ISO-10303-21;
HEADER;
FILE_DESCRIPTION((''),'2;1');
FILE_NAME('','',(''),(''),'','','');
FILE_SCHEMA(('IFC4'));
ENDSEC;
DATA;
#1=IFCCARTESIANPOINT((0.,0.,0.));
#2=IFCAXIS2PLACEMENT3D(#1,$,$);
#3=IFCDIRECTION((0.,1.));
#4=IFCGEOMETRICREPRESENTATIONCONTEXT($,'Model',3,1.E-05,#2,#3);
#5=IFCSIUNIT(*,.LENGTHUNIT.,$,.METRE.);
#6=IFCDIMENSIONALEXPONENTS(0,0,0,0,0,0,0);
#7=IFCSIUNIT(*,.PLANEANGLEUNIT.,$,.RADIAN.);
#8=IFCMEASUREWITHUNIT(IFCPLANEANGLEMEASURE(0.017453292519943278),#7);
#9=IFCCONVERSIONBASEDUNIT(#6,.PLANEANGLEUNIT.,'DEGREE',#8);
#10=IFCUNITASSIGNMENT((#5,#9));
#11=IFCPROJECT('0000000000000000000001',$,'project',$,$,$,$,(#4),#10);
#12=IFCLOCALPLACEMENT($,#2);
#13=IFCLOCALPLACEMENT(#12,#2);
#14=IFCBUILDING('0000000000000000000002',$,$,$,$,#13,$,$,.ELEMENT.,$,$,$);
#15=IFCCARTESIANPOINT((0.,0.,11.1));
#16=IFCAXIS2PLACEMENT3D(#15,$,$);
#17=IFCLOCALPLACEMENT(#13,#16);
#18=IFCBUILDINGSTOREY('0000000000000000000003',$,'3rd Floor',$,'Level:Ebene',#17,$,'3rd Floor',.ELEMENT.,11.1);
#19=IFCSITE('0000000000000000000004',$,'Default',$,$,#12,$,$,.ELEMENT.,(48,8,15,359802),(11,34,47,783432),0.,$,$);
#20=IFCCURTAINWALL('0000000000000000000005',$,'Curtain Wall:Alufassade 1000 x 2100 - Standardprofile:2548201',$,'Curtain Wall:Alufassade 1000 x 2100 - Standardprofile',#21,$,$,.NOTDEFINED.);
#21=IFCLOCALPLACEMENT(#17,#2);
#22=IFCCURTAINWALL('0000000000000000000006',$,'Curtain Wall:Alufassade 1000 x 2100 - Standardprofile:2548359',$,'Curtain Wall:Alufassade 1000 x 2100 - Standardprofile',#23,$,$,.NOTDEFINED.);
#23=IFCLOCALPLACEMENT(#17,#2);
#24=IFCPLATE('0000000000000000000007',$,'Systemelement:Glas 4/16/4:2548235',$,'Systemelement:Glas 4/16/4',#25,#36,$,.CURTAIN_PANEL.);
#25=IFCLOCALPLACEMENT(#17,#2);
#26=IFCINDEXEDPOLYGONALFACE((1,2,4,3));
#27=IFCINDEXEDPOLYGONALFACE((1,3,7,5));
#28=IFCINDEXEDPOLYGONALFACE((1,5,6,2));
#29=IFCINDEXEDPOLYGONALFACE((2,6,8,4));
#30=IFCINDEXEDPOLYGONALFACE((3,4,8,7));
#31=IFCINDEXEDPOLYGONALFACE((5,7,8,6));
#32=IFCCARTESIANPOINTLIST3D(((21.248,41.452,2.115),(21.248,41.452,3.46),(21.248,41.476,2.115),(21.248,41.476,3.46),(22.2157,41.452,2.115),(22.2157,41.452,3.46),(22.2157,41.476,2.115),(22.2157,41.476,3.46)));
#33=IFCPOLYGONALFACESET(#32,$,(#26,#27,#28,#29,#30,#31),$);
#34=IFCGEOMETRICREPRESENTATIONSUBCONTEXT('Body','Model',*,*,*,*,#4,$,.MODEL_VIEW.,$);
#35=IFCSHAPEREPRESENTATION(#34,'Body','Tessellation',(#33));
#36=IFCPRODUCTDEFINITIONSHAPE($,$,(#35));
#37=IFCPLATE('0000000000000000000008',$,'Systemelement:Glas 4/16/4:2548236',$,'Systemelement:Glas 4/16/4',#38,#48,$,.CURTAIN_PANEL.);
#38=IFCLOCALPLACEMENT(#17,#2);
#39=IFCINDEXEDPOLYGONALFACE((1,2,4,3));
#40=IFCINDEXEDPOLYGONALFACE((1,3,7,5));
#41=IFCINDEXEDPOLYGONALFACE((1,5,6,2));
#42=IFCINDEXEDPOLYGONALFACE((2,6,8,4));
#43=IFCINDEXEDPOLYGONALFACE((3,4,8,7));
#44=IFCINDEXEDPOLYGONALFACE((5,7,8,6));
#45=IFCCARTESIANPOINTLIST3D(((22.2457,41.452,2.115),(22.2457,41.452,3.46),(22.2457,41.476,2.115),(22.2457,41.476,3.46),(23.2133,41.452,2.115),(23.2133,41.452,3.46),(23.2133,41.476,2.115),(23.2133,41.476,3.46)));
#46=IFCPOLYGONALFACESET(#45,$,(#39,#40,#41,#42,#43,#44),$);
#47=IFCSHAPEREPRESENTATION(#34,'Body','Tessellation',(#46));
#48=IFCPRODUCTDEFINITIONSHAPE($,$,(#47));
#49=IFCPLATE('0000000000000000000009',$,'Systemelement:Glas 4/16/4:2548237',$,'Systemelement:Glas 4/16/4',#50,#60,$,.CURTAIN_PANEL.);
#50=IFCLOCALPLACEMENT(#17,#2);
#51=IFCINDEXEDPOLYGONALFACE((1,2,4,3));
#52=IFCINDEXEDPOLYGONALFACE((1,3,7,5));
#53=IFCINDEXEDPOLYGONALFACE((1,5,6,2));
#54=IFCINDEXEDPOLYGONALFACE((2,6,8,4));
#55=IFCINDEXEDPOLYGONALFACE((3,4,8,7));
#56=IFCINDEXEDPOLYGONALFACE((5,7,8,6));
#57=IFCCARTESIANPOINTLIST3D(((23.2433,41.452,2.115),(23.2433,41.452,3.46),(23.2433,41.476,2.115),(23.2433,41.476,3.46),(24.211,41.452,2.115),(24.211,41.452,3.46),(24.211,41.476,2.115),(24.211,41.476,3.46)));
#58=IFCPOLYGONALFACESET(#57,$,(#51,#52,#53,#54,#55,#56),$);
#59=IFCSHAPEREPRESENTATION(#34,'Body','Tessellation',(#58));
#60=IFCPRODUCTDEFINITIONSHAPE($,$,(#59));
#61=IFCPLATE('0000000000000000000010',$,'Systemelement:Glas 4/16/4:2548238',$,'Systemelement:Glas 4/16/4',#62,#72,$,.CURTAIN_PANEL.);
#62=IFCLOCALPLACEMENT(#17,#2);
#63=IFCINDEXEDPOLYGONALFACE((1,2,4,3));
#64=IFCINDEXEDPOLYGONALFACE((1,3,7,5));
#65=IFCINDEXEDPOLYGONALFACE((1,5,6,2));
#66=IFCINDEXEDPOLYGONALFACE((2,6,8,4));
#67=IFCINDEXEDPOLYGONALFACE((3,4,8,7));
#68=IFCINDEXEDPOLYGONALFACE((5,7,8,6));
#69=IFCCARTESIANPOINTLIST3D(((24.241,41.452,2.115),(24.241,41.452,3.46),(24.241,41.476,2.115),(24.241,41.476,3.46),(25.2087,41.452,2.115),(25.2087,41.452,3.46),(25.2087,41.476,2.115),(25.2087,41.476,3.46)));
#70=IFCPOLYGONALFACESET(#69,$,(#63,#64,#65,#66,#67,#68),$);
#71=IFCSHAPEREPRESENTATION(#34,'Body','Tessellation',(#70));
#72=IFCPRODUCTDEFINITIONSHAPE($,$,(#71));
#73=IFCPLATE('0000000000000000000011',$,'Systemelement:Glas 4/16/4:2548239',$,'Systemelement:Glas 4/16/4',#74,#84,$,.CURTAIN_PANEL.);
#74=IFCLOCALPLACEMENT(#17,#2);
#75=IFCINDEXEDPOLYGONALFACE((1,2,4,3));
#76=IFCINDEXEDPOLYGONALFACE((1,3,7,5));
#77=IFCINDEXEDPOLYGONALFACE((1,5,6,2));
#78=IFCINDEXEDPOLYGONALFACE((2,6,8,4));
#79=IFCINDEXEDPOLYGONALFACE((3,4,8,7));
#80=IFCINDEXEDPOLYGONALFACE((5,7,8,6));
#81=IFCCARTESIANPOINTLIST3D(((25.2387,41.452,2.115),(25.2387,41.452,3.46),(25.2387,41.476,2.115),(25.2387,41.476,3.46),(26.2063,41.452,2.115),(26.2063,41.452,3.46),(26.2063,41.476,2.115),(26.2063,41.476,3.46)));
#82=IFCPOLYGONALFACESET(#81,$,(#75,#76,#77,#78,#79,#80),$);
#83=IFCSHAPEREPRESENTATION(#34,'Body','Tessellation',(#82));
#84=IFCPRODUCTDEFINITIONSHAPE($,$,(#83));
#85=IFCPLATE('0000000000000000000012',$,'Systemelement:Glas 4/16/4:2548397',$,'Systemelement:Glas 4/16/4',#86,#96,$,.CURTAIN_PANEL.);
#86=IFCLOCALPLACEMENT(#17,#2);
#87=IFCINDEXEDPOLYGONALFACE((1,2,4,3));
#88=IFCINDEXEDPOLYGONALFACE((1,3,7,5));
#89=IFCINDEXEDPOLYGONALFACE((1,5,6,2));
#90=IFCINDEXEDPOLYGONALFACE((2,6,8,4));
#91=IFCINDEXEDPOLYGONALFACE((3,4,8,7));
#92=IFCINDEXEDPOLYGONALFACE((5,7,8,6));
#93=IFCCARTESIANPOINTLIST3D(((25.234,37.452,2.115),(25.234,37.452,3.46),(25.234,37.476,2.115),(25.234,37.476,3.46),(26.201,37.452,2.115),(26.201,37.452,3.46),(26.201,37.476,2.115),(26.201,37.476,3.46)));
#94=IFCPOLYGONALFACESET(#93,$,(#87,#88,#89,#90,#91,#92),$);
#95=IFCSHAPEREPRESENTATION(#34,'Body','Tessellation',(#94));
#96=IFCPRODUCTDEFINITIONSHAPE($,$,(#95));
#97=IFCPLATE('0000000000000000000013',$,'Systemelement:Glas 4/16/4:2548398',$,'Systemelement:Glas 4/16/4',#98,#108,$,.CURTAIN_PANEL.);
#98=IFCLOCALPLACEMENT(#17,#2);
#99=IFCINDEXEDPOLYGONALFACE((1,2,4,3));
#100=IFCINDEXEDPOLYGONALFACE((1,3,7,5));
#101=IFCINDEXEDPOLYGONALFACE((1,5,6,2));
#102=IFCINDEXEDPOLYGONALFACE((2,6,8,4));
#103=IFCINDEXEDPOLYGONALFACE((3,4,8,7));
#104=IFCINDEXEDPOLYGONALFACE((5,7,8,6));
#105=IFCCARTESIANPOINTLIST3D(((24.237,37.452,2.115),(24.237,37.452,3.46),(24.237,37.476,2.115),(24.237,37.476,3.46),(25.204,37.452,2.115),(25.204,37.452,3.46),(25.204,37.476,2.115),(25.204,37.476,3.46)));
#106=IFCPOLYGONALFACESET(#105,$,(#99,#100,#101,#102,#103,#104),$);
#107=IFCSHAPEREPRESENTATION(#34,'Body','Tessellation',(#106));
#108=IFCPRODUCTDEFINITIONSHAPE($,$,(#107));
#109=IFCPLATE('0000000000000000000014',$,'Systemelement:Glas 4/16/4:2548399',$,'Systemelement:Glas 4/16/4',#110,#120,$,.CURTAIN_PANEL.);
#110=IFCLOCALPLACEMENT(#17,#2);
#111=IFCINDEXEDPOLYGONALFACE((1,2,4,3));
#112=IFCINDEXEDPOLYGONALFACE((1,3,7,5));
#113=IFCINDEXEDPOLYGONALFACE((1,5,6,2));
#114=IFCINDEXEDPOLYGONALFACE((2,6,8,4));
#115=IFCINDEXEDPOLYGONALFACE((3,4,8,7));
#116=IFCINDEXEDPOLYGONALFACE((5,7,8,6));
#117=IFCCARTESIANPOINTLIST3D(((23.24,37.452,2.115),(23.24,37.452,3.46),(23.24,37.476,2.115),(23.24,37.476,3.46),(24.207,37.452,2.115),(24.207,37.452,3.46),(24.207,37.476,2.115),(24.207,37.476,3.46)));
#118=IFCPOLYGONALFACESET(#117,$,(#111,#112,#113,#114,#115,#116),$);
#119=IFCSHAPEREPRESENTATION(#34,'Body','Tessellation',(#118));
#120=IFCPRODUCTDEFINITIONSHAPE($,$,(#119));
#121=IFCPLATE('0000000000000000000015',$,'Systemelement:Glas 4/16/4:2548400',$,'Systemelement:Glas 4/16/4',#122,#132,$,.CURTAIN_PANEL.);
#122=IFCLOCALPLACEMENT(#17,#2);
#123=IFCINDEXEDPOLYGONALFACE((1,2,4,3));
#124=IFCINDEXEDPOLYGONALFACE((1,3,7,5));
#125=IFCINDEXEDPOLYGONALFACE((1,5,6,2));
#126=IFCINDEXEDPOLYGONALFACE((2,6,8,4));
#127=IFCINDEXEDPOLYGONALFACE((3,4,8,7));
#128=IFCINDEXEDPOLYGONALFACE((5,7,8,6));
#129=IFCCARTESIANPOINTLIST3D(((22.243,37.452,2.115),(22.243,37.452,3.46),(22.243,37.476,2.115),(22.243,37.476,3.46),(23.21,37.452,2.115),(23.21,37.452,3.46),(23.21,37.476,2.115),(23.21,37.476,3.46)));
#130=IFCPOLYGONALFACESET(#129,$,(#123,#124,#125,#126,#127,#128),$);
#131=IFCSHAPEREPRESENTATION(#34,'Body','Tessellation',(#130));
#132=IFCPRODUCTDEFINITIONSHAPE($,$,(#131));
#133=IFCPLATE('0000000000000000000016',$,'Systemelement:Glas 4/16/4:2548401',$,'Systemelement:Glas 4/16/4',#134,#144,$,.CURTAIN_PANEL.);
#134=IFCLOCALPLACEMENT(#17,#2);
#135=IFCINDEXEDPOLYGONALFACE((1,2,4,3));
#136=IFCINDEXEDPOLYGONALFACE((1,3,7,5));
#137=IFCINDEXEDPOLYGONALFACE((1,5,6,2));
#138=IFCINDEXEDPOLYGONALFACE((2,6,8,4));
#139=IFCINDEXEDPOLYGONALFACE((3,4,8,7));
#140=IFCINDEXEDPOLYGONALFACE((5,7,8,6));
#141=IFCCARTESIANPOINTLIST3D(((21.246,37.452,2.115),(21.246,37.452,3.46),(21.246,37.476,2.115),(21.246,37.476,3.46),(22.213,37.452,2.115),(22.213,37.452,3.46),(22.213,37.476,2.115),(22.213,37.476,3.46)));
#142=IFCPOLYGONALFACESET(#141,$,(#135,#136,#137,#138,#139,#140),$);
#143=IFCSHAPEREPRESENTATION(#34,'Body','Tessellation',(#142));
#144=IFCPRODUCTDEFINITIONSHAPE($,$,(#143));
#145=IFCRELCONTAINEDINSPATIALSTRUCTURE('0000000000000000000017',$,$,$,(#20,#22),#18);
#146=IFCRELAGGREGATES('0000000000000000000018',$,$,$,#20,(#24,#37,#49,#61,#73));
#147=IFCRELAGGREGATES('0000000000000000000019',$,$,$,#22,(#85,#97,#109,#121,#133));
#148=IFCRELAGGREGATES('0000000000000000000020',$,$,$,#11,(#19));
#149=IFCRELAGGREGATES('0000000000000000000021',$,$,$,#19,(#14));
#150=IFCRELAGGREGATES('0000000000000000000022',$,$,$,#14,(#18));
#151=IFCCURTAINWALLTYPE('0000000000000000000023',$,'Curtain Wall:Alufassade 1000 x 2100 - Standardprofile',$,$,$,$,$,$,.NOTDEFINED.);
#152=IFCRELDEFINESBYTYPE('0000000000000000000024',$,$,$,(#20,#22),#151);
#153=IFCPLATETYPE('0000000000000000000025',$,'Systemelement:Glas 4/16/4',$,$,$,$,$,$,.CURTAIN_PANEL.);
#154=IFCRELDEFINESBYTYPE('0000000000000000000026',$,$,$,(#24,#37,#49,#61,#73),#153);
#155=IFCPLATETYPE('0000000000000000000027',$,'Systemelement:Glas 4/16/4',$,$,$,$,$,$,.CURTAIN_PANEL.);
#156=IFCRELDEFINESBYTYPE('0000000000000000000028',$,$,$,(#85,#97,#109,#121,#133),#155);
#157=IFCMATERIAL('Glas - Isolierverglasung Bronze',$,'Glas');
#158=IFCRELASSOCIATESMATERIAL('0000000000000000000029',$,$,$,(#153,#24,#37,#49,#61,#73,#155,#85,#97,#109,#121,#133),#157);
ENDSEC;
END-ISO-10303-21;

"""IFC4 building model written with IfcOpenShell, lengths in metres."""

from ifc_helpers import new_model, entity, si_unit, converted_unit, direction, frame, origin, place, context, subcontext, project, spatial, indexed_curve, outline, extrude, source, transform, mapped, material, type_object, type_shapes, element, aggregate, save


model = new_model("IFC4")

# Units and contexts
model_context = context("Model", 3, precision=1e-05, world=origin(), true_north=direction((0.0, 1.0)))
body_context = subcontext(model_context, "Body", "Model", "MODEL_VIEW")
ifc_project = project(units=[si_unit("LENGTHUNIT", "METRE"), converted_unit("PLANEANGLEUNIT", "DEGREE", entity("IfcPlaneAngleMeasure", 0.017453292519943278), si_unit("PLANEANGLEUNIT", "RADIAN"), dimensions=[0, 0, 0, 0, 0, 0, 0])], contexts=[model_context])

# Site, building, storey
site_placement = place(None, origin())
site = spatial("IfcSite", under=ifc_project, at=site_placement, Name="Default", CompositionType="ELEMENT", RefLatitude=(48, 8, 15, 359802), RefLongitude=(11, 34, 47, 783432), RefElevation=0.0)
building_placement = place(site_placement, origin())
building = spatial("IfcBuilding", under=site, at=building_placement, CompositionType="ELEMENT")
storey_placement = place(building_placement, frame((0.0, 0.0, 11.1)))
storey = spatial("IfcBuildingStorey", under=building, at=storey_placement, Name="3rd Floor", ObjectType="Level:Ebene", LongName="3rd Floor", CompositionType="ELEMENT", Elevation=11.1)

# Curtain walls
curtain_wall_type = type_object("IfcCurtainWallType", Name="Curtain Wall:Alufassade 1000 x 2100 - Standardprofile", PredefinedType="NOTDEFINED")
curtain_wall_1_placement = place(storey_placement, frame((0.0, 0.0, -11.1)))
curtain_wall_1 = element("IfcCurtainWall", 1, at=curtain_wall_1_placement, inside=storey, type_object=curtain_wall_type, Name="Curtain Wall:Alufassade 1000 x 2100 - Standardprofile:2548201", ObjectType="Curtain Wall:Alufassade 1000 x 2100 - Standardprofile", PredefinedType="NOTDEFINED")
curtain_wall_2_placement = place(storey_placement, frame((0.0, 0.0, -11.1)))
curtain_wall_2 = element("IfcCurtainWall", 2, at=curtain_wall_2_placement, inside=storey, type_object=curtain_wall_type, Name="Curtain Wall:Alufassade 1000 x 2100 - Standardprofile:2548359", ObjectType="Curtain Wall:Alufassade 1000 x 2100 - Standardprofile", PredefinedType="NOTDEFINED")

# Plates
ifc_material_1 = material(Name="Glas - Isolierverglasung Bronze", Category="Glas")
plate_type_1 = type_object("IfcPlateType", Name="Systemelement:Glas 4/16/4", PredefinedType="CURTAIN_PANEL", material=ifc_material_1)
shared_shape_1 = source(origin(), body_context, "Body", "SweptSolid", [
    extrude(outline(indexed_curve([(-0.012, -0.4838), (0.012, -0.4838), (0.012, 0.4838), (-0.012, 0.4838), (-0.012, -0.4838)], self_intersect=False)), frame((0.0, 0.0, 0.0), z_axis=(0.0, 0.0, 1.0), x_axis=(0.0, 1.0, 0.0)), (0.0, 0.0, 1.0), 1.345),
])
type_shapes(plate_type_1, [shared_shape_1])
plate_1_placement = place(curtain_wall_1_placement, frame((21.7318, 41.464, 13.215)))
plate_1 = element("IfcPlate", 3, at=plate_1_placement, type_object=plate_type_1, material=ifc_material_1, Name="Systemelement:Glas 4/16/4:2548235", ObjectType="Systemelement:Glas 4/16/4", PredefinedType="CURTAIN_PANEL", context=body_context, shape_type="MappedRepresentation", body=[
    mapped(shared_shape_1, transform((0.0, 0.0, 0.0), scale=1.0)),
])
plate_2_placement = place(curtain_wall_1_placement, frame((22.7295, 41.464, 13.215)))
plate_2 = element("IfcPlate", 4, at=plate_2_placement, type_object=plate_type_1, material=ifc_material_1, Name="Systemelement:Glas 4/16/4:2548236", ObjectType="Systemelement:Glas 4/16/4", PredefinedType="CURTAIN_PANEL", context=body_context, shape_type="MappedRepresentation", body=[
    mapped(shared_shape_1, transform((0.0, 0.0, 0.0), scale=1.0)),
])
plate_3_placement = place(curtain_wall_1_placement, frame((23.7272, 41.464, 13.215)))
plate_3 = element("IfcPlate", 5, at=plate_3_placement, type_object=plate_type_1, material=ifc_material_1, Name="Systemelement:Glas 4/16/4:2548237", ObjectType="Systemelement:Glas 4/16/4", PredefinedType="CURTAIN_PANEL", context=body_context, shape_type="MappedRepresentation", body=[
    mapped(shared_shape_1, transform((0.0, 0.0, 0.0), scale=1.0)),
])
plate_4_placement = place(curtain_wall_1_placement, frame((24.7248, 41.464, 13.215)))
plate_4 = element("IfcPlate", 6, at=plate_4_placement, type_object=plate_type_1, material=ifc_material_1, Name="Systemelement:Glas 4/16/4:2548238", ObjectType="Systemelement:Glas 4/16/4", PredefinedType="CURTAIN_PANEL", context=body_context, shape_type="MappedRepresentation", body=[
    mapped(shared_shape_1, transform((0.0, 0.0, 0.0), scale=1.0)),
])
plate_5_placement = place(curtain_wall_1_placement, frame((25.7225, 41.464, 13.215)))
plate_5 = element("IfcPlate", 7, at=plate_5_placement, type_object=plate_type_1, material=ifc_material_1, Name="Systemelement:Glas 4/16/4:2548239", ObjectType="Systemelement:Glas 4/16/4", PredefinedType="CURTAIN_PANEL", context=body_context, shape_type="MappedRepresentation", body=[
    mapped(shared_shape_1, transform((0.0, 0.0, 0.0), scale=1.0)),
])
aggregate(curtain_wall_1, [plate_1, plate_2, plate_3, plate_4, plate_5])
plate_type_2 = type_object("IfcPlateType", Name="Systemelement:Glas 4/16/4", PredefinedType="CURTAIN_PANEL", material=ifc_material_1)
shared_shape_2 = source(origin(), body_context, "Body", "SweptSolid", [
    extrude(outline(indexed_curve([(-0.012, -0.4835), (0.012, -0.4835), (0.012, 0.4835), (-0.012, 0.4835), (-0.012, -0.4835)], self_intersect=False)), frame((0.0, 0.0, 0.0), z_axis=(0.0, 0.0, 1.0), x_axis=(0.0, 1.0, 0.0)), (0.0, 0.0, 1.0), 1.345),
])
type_shapes(plate_type_2, [shared_shape_2])
plate_6_placement = place(curtain_wall_2_placement, frame((25.7175, 37.464, 13.215), z_axis=(0.0, 0.0, 1.0), x_axis=(-1.0, 0.0, 0.0)))
plate_6 = element("IfcPlate", 8, at=plate_6_placement, type_object=plate_type_2, material=ifc_material_1, Name="Systemelement:Glas 4/16/4:2548397", ObjectType="Systemelement:Glas 4/16/4", PredefinedType="CURTAIN_PANEL", context=body_context, shape_type="MappedRepresentation", body=[
    mapped(shared_shape_2, transform((0.0, 0.0, 0.0), scale=1.0)),
])
plate_7_placement = place(curtain_wall_2_placement, frame((24.7205, 37.464, 13.215), z_axis=(0.0, 0.0, 1.0), x_axis=(-1.0, 0.0, 0.0)))
plate_7 = element("IfcPlate", 9, at=plate_7_placement, type_object=plate_type_2, material=ifc_material_1, Name="Systemelement:Glas 4/16/4:2548398", ObjectType="Systemelement:Glas 4/16/4", PredefinedType="CURTAIN_PANEL", context=body_context, shape_type="MappedRepresentation", body=[
    mapped(shared_shape_2, transform((0.0, 0.0, 0.0), scale=1.0)),
])
plate_8_placement = place(curtain_wall_2_placement, frame((23.7235, 37.464, 13.215), z_axis=(0.0, 0.0, 1.0), x_axis=(-1.0, 0.0, 0.0)))
plate_8 = element("IfcPlate", 10, at=plate_8_placement, type_object=plate_type_2, material=ifc_material_1, Name="Systemelement:Glas 4/16/4:2548399", ObjectType="Systemelement:Glas 4/16/4", PredefinedType="CURTAIN_PANEL", context=body_context, shape_type="MappedRepresentation", body=[
    mapped(shared_shape_2, transform((0.0, 0.0, 0.0), scale=1.0)),
])
plate_9_placement = place(curtain_wall_2_placement, frame((22.7265, 37.464, 13.215), z_axis=(0.0, 0.0, 1.0), x_axis=(-1.0, 0.0, 0.0)))
plate_9 = element("IfcPlate", 11, at=plate_9_placement, type_object=plate_type_2, material=ifc_material_1, Name="Systemelement:Glas 4/16/4:2548400", ObjectType="Systemelement:Glas 4/16/4", PredefinedType="CURTAIN_PANEL", context=body_context, shape_type="MappedRepresentation", body=[
    mapped(shared_shape_2, transform((0.0, 0.0, 0.0), scale=1.0)),
])
plate_10_placement = place(curtain_wall_2_placement, frame((21.7295, 37.464, 13.215), z_axis=(0.0, 0.0, 1.0), x_axis=(-1.0, 0.0, 0.0)))
plate_10 = element("IfcPlate", 12, at=plate_10_placement, type_object=plate_type_2, material=ifc_material_1, Name="Systemelement:Glas 4/16/4:2548401", ObjectType="Systemelement:Glas 4/16/4", PredefinedType="CURTAIN_PANEL", context=body_context, shape_type="MappedRepresentation", body=[
    mapped(shared_shape_2, transform((0.0, 0.0, 0.0), scale=1.0)),
])
aggregate(curtain_wall_2, [plate_6, plate_7, plate_8, plate_9, plate_10])

save(model, "model.ifc")
